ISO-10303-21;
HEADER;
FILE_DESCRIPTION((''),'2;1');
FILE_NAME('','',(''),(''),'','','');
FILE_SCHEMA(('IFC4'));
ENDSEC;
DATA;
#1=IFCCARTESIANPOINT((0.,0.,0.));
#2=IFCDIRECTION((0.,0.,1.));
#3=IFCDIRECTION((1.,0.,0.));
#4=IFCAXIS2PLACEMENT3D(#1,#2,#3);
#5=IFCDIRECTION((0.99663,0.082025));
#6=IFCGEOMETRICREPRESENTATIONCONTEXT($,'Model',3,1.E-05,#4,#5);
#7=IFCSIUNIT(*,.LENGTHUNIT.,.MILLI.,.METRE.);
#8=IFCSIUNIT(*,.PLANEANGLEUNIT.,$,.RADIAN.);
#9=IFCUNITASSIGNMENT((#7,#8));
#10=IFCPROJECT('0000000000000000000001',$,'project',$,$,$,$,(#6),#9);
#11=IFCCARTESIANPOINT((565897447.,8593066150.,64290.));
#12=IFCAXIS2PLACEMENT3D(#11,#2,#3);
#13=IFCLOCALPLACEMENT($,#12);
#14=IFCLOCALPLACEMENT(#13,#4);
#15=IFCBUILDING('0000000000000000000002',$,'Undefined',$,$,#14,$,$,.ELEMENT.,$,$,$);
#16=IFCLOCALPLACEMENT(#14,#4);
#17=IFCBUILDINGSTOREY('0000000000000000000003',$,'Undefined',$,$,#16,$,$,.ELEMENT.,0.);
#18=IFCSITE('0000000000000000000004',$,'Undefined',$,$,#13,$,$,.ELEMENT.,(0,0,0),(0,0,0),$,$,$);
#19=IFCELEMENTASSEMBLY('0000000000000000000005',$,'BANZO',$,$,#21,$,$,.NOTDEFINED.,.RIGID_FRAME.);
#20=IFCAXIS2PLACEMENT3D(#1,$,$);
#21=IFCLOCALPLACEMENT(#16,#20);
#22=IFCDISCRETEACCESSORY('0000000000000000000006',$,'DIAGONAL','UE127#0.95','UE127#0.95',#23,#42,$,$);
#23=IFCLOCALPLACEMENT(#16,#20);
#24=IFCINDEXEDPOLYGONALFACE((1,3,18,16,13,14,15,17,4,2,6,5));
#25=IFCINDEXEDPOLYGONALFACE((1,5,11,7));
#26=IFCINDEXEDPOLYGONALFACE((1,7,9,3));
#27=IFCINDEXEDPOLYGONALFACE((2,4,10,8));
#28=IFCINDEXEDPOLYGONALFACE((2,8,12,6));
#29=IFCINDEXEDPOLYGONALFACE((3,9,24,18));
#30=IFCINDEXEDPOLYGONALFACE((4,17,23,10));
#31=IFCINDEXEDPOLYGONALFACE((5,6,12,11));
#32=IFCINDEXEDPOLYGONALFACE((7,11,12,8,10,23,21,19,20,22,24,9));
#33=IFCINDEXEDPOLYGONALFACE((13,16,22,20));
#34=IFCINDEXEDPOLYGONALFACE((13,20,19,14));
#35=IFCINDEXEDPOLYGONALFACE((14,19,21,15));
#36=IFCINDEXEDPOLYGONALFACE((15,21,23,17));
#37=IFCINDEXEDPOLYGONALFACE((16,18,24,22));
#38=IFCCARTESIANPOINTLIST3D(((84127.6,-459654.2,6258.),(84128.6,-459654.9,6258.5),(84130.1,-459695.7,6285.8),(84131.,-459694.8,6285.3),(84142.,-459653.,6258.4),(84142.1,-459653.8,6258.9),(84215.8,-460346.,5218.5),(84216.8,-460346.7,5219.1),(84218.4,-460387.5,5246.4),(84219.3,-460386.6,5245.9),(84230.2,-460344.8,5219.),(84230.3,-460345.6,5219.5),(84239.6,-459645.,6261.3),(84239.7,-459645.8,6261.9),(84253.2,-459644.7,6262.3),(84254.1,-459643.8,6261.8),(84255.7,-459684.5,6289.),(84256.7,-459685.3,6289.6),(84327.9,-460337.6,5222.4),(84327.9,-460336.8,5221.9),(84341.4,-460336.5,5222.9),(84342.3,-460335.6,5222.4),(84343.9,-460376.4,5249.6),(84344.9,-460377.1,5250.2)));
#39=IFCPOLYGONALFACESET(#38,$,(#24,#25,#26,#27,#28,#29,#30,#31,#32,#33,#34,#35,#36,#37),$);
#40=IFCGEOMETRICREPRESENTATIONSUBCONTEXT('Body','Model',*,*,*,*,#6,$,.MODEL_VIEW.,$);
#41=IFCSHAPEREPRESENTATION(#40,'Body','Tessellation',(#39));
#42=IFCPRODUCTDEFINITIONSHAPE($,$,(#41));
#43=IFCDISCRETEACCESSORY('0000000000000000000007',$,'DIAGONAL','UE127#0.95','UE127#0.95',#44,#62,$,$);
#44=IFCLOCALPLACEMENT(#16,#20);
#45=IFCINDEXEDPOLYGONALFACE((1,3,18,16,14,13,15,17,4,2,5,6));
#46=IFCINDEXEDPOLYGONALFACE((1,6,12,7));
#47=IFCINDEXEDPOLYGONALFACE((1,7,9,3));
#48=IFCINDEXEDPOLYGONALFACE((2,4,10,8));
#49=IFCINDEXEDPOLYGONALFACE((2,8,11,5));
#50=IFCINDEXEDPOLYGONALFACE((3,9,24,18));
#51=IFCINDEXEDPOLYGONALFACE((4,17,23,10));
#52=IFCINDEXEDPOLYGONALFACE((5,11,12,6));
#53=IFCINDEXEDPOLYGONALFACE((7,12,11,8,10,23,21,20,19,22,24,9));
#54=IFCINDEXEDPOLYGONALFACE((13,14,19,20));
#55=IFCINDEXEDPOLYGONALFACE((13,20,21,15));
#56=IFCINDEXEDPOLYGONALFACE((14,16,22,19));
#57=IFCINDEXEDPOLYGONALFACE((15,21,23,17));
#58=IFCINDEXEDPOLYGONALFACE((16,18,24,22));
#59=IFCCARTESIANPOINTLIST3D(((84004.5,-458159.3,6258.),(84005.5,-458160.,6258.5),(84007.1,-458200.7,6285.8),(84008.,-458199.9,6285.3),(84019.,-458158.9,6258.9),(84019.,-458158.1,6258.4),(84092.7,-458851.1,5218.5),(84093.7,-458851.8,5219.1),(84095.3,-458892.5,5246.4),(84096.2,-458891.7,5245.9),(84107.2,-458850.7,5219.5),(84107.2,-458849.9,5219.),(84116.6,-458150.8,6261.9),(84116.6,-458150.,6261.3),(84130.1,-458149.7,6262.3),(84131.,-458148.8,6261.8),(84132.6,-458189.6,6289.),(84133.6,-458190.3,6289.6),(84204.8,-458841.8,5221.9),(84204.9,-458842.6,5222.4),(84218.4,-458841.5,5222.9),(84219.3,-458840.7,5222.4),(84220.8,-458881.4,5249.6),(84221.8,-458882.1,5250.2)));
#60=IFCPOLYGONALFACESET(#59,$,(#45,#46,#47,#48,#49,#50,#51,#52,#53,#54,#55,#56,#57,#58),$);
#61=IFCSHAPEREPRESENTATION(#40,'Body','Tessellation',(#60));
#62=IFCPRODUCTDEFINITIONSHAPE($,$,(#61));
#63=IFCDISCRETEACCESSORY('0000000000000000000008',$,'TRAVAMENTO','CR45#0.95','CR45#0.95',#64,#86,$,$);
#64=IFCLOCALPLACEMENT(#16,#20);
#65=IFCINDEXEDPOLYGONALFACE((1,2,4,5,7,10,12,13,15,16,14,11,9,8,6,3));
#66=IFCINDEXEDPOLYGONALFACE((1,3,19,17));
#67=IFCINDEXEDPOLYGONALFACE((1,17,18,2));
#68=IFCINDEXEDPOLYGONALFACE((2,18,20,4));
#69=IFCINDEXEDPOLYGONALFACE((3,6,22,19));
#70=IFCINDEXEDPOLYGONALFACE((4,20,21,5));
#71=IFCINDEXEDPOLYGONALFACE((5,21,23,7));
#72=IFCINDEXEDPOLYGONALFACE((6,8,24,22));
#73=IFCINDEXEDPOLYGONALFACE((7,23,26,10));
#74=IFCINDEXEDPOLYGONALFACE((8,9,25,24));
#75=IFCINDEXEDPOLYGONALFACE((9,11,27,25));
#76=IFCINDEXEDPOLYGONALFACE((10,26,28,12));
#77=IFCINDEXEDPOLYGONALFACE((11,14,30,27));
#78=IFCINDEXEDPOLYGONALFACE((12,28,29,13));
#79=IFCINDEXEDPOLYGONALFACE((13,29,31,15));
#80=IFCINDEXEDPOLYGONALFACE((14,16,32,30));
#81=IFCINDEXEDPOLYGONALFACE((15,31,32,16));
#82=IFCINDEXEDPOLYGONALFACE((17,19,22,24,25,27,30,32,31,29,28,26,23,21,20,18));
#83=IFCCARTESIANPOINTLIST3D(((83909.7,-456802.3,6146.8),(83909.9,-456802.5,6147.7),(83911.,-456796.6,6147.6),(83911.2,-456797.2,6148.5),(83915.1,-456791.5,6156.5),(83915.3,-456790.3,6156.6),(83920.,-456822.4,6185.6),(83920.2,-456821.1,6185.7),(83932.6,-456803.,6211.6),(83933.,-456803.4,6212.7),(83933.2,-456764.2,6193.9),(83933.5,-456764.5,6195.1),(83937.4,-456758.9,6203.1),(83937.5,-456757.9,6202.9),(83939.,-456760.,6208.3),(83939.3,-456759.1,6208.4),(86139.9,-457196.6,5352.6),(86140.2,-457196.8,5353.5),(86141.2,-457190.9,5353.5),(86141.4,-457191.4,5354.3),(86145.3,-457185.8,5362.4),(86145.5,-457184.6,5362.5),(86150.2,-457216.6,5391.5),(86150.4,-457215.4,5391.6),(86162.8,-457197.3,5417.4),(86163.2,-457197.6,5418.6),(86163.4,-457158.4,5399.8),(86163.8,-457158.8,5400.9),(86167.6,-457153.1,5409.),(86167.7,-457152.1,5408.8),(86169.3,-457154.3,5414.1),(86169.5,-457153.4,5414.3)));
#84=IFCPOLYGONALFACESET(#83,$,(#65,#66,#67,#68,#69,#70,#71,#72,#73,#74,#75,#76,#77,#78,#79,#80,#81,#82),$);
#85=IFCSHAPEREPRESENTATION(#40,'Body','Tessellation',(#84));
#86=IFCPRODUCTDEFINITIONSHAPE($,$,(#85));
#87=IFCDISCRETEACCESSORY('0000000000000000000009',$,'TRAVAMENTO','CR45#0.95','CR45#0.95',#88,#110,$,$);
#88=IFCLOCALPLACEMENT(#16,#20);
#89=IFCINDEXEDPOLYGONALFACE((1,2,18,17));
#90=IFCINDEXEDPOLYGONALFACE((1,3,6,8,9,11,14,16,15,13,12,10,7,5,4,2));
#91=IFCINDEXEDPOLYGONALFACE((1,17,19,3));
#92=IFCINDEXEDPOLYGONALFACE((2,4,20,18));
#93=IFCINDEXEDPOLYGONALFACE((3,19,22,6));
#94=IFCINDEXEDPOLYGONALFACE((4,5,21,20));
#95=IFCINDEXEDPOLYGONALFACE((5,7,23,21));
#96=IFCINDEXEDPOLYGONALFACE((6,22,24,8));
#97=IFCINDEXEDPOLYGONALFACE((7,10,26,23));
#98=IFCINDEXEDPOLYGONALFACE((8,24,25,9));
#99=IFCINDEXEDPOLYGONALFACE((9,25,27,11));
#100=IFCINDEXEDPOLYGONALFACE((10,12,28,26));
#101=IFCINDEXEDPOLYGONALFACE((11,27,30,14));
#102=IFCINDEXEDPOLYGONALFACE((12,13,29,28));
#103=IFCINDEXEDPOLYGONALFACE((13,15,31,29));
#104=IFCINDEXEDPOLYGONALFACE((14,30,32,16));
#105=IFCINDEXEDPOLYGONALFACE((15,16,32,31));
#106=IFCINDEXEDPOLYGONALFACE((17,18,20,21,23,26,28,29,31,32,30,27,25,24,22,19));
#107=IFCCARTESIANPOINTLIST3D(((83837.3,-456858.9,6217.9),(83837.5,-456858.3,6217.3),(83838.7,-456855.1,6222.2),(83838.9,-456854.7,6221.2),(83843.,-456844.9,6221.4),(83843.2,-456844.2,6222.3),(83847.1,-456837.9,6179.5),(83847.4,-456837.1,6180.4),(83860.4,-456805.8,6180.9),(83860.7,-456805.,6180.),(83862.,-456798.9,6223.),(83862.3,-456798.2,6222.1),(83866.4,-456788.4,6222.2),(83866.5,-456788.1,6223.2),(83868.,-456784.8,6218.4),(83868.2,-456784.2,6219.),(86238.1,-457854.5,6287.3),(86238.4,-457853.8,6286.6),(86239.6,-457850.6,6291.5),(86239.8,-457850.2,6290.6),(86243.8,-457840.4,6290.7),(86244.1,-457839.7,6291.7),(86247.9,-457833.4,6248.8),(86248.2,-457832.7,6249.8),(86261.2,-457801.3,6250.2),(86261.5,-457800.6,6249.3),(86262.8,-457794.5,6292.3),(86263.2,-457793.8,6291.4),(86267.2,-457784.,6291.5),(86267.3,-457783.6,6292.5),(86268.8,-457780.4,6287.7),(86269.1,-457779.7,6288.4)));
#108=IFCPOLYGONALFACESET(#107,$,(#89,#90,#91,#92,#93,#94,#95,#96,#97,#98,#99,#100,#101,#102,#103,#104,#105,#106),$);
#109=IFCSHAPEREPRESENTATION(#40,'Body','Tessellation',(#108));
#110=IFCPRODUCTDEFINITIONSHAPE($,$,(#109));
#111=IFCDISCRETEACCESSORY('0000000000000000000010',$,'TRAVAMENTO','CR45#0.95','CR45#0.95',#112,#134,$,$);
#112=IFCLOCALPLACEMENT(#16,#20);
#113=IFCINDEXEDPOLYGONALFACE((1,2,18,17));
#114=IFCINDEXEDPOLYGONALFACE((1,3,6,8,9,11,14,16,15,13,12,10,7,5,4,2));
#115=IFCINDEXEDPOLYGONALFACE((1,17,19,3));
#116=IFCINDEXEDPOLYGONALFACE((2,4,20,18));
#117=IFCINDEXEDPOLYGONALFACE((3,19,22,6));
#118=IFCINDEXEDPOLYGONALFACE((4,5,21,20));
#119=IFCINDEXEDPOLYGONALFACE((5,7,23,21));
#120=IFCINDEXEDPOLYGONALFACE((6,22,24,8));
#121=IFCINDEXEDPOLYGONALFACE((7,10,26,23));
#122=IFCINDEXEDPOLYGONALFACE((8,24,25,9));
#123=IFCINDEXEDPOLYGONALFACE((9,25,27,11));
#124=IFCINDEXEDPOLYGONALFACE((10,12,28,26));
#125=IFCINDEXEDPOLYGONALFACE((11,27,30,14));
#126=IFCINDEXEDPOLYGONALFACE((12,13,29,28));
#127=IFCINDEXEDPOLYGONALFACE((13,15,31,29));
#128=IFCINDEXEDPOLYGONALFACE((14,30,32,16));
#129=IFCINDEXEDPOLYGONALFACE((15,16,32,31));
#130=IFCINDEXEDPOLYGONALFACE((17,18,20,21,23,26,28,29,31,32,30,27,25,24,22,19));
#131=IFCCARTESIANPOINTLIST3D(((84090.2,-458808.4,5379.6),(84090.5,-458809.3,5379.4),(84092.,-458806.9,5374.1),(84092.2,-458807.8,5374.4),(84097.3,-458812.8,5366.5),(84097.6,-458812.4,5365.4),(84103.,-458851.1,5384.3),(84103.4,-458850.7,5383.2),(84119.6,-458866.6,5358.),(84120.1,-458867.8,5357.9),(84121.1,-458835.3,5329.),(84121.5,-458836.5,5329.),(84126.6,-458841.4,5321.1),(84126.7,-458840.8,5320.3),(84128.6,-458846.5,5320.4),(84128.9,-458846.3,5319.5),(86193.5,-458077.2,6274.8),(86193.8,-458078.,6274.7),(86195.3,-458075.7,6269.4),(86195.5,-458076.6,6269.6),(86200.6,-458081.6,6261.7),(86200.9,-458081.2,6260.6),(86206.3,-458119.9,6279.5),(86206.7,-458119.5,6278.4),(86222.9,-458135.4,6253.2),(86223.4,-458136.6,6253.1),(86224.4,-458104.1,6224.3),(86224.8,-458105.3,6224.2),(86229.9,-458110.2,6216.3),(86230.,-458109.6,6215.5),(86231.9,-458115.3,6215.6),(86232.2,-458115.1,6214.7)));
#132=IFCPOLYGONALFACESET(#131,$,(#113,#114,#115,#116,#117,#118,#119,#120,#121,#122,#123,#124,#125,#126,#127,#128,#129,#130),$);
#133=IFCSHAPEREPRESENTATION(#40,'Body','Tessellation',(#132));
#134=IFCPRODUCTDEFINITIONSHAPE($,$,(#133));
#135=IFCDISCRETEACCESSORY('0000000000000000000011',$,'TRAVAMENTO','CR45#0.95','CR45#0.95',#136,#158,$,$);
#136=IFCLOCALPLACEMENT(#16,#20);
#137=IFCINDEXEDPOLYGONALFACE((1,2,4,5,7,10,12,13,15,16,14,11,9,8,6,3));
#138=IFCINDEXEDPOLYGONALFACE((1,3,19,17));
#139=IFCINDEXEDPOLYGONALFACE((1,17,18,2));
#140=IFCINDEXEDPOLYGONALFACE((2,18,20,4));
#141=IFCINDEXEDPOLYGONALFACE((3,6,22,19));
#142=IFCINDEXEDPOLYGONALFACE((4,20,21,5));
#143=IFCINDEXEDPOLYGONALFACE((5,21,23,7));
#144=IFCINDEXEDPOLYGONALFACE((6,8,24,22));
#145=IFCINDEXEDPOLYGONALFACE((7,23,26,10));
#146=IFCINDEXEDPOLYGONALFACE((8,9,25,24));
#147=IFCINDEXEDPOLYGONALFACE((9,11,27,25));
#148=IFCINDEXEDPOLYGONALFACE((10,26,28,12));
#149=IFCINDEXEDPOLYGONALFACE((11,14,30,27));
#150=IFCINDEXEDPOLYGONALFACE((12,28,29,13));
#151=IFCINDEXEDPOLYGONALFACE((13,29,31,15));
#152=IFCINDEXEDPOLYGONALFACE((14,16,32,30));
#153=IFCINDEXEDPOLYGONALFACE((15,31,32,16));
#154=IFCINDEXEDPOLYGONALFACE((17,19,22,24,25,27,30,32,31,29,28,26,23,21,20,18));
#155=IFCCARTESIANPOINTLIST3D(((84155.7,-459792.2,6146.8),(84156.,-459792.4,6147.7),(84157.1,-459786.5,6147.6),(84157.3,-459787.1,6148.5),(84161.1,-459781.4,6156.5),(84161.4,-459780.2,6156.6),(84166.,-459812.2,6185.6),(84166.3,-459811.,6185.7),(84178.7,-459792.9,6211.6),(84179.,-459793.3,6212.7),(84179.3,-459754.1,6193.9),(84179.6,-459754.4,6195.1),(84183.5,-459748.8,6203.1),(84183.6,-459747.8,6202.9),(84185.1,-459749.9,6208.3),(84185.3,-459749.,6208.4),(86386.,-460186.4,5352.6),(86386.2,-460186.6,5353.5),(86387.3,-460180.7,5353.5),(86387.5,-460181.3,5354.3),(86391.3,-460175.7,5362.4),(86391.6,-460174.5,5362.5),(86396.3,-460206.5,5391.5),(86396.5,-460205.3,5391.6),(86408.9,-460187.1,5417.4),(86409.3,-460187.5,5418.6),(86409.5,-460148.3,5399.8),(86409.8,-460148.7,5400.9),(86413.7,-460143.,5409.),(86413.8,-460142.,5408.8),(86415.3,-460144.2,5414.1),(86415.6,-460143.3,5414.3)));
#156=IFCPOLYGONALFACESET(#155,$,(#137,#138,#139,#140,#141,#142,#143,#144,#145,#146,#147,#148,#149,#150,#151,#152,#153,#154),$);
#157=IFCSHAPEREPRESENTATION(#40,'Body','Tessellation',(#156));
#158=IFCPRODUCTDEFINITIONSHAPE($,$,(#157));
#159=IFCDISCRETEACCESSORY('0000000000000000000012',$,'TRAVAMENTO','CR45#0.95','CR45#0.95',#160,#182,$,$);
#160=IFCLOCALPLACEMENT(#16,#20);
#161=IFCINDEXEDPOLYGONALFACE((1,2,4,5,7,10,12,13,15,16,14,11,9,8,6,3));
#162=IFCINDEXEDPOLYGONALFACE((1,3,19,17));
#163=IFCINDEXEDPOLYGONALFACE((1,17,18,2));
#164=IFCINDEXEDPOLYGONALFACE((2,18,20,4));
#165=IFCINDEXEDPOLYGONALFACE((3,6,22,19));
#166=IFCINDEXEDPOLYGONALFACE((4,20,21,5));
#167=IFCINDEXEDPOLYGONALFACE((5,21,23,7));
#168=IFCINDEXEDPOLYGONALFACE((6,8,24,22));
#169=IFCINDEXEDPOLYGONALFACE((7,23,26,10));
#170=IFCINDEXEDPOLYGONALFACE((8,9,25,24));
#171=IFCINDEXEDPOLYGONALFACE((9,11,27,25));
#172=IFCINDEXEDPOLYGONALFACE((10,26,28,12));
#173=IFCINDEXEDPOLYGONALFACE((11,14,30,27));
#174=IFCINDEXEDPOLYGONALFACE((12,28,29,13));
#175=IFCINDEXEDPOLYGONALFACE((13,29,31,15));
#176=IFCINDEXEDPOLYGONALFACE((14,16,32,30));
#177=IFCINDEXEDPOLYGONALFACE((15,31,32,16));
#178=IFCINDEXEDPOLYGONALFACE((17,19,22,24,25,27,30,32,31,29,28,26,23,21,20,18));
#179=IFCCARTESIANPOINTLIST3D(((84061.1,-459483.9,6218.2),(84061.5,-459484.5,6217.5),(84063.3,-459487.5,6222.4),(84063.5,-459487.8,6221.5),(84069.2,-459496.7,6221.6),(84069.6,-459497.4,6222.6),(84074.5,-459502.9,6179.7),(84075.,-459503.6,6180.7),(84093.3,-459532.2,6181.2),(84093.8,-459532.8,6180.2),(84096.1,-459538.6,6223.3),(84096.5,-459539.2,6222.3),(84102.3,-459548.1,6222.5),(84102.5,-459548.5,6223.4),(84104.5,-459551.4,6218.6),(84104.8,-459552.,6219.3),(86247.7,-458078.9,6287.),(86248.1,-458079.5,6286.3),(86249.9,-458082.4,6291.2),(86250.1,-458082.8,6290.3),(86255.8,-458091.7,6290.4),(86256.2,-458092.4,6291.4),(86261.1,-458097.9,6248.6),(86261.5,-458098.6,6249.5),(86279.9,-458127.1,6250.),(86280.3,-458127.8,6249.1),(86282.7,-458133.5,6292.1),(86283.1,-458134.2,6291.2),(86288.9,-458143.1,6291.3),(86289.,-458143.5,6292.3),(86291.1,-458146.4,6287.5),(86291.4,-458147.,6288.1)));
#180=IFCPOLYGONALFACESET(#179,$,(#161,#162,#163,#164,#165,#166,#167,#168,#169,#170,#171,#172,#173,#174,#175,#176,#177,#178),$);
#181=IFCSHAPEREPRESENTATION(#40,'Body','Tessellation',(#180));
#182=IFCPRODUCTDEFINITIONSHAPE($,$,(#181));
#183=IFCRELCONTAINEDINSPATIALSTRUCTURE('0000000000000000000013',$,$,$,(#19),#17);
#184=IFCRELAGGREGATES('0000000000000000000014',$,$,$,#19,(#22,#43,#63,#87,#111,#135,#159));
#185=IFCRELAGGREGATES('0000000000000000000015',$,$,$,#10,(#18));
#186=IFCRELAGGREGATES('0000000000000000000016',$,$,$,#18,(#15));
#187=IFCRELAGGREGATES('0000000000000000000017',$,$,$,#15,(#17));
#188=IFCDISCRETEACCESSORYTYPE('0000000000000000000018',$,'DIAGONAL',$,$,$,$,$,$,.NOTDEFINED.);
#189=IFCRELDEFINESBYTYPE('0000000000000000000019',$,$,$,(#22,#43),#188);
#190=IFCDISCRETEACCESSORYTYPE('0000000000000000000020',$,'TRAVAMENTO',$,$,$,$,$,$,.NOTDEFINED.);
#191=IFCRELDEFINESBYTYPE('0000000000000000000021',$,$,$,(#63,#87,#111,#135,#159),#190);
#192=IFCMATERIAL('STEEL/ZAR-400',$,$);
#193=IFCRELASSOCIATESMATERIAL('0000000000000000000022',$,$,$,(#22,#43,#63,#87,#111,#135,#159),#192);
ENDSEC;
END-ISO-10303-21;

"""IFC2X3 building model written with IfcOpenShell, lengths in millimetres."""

from ifc_helpers import new_model, si_unit, direction, frame, frame_2d, origin_with_axes, place, context, subcontext, project, spatial, polyline, c_section, outline, extrude, material, type_object, element, aggregate, save


model = new_model("IFC2X3")

# Units and contexts
model_context = context("Model", 3, precision=1e-05, world=origin_with_axes(), true_north=direction((0.99663, 0.082025)))
body_context = subcontext(model_context, "Body", "Model", "MODEL_VIEW")
ifc_project = project(units=[si_unit("LENGTHUNIT", "METRE", prefix="MILLI"), si_unit("PLANEANGLEUNIT", "RADIAN")], contexts=[model_context])

# Site, building, storey
site_placement = place(None, frame((565897447.0, 8593066150.0, 64290.0), z_axis=(0.0, 0.0, 1.0), x_axis=(1.0, 0.0, 0.0)))
site = spatial("IfcSite", under=ifc_project, at=site_placement, Name="Undefined", CompositionType="ELEMENT", RefLatitude=(0, 0, 0), RefLongitude=(0, 0, 0))
building_placement = place(site_placement, origin_with_axes())
building = spatial("IfcBuilding", under=site, at=building_placement, Name="Undefined", CompositionType="ELEMENT")
storey_placement = place(building_placement, origin_with_axes())
storey = spatial("IfcBuildingStorey", under=building, at=storey_placement, Name="Undefined", CompositionType="ELEMENT", Elevation=0.0)

# Element assembly
assembly_1_placement = place(storey_placement, origin_with_axes())
assembly_1 = element("IfcElementAssembly", 1, at=assembly_1_placement, inside=storey, Name="BANZO", AssemblyPlace="NOTDEFINED", PredefinedType="RIGID_FRAME")

# Discrete accessories
ifc_material_1 = material(Name="STEEL/ZAR-400")
discrete_accessory_type_1 = type_object("IfcDiscreteAccessoryType", Name="DIAGONAL")
discrete_accessory_1_placement = place(assembly_1_placement, frame((84192.1, -459669.7, 6273.8), z_axis=(-0.996182, -0.081989, -0.029987), x_axis=(0.070485, -0.552697, -0.830396)))
discrete_accessory_1 = element("IfcDiscreteAccessory", 2, at=discrete_accessory_1_placement, type_object=discrete_accessory_type_1, material=ifc_material_1, Name="DIAGONAL", Description="UE127#0.95", ObjectType="UE127#0.95", context=body_context, shape_type="SweptSolid", body=[
    extrude(c_section(Depth=127.0, Width=50.0, WallThickness=0.9, Girth=14.5, at=frame_2d((0.0, 0.0), x_axis=(1.0, 0.0))), frame((1251.7, 0.0, 0.0), z_axis=(-1.0, 0.0, 0.0), x_axis=(0.0, -1.0, 0.0)), (0.0, 0.0, 1.0), 1251.7),
])
discrete_accessory_2_placement = place(assembly_1_placement, frame((84069.1, -458174.8, 6273.8), z_axis=(-0.996182, -0.081989, -0.029987), x_axis=(0.070485, -0.552697, -0.830396)))
discrete_accessory_2 = element("IfcDiscreteAccessory", 3, at=discrete_accessory_2_placement, type_object=discrete_accessory_type_1, material=ifc_material_1, Name="DIAGONAL", Description="UE127#0.95", ObjectType="UE127#0.95", context=body_context, shape_type="SweptSolid", body=[
    extrude(c_section(Depth=127.0, Width=50.0, WallThickness=0.9, Girth=14.5, at=frame_2d((0.0, 0.0), x_axis=(1.0, 0.0))), frame((1251.7, 0.0, 0.0), z_axis=(-1.0, 0.0, 0.0), x_axis=(0.0, -1.0, 0.0)), (0.0, 0.0, 1.0), 1251.7),
])
discrete_accessory_type_2 = type_object("IfcDiscreteAccessoryType", Name="TRAVAMENTO")
discrete_accessory_3_placement = place(assembly_1_placement, frame((86155.5, -457189.5, 5392.8), z_axis=(0.05151, -0.82934, 0.556366), x_axis=(-0.929259, 0.164269, 0.330898)))
discrete_accessory_3 = element("IfcDiscreteAccessory", 4, at=discrete_accessory_3_placement, type_object=discrete_accessory_type_2, material=ifc_material_1, Name="TRAVAMENTO", Description="CR45#0.95", ObjectType="CR45#0.95", context=body_context, shape_type="SweptSolid", body=[
    extrude(outline(polyline([(-35.5, -20.5), (-24.9, -20.5), (-17.4, 21.5), (18.1, 21.5), (25.6, -20.5), (36.2, -20.5), (40.1, -16.6), (40.8, -17.3), (36.6, -21.5), (24.8, -21.5), (17.3, 20.5), (-16.6, 20.5), (-24.1, -21.5), (-35.9, -21.5), (-40.1, -17.3), (-39.4, -16.6), (-35.5, -20.5)])), frame((2400.0, 0.0, 0.0), z_axis=(-1.0, 0.0, 0.0), x_axis=(0.0, -1.0, 0.0)), (0.0, 0.0, 1.0), 2400.0),
])
discrete_accessory_4_placement = place(assembly_1_placement, frame((86254.2, -457816.7, 6270.5), z_axis=(0.029887, 0.002459, -0.99955), x_axis=(-0.923403, 0.382903, -0.026668)))
discrete_accessory_4 = element("IfcDiscreteAccessory", 5, at=discrete_accessory_4_placement, type_object=discrete_accessory_type_2, material=ifc_material_1, Name="TRAVAMENTO", Description="CR45#0.95", ObjectType="CR45#0.95", context=body_context, shape_type="SweptSolid", body=[
    extrude(outline(polyline([(-35.5, -20.5), (-24.9, -20.5), (-17.4, 21.5), (18.1, 21.5), (25.6, -20.5), (36.2, -20.5), (40.1, -16.6), (40.8, -17.3), (36.6, -21.5), (24.8, -21.5), (17.3, 20.5), (-16.6, 20.5), (-24.1, -21.5), (-35.9, -21.5), (-40.1, -17.3), (-39.4, -16.6), (-35.5, -20.5)])), frame((2600.0, 0.0, 0.0), z_axis=(-1.0, 0.0, 0.0), x_axis=(0.0, -1.0, 0.0)), (0.0, 0.0, 1.0), 2600.0),
])
discrete_accessory_5_placement = place(assembly_1_placement, frame((84110.3, -458841.5, 5359.4), z_axis=(0.05151, -0.82934, 0.556366), x_axis=(0.876377, 0.30467, 0.373015)))
discrete_accessory_5 = element("IfcDiscreteAccessory", 6, at=discrete_accessory_5_placement, type_object=discrete_accessory_type_2, material=ifc_material_1, Name="TRAVAMENTO", Description="CR45#0.95", ObjectType="CR45#0.95", context=body_context, shape_type="SweptSolid", body=[
    extrude(outline(polyline([(-35.5, -20.5), (-24.9, -20.5), (-17.4, 21.5), (18.1, 21.5), (25.6, -20.5), (36.2, -20.5), (40.1, -16.6), (40.8, -17.3), (36.6, -21.5), (24.8, -21.5), (17.3, 20.5), (-16.6, 20.5), (-24.1, -21.5), (-35.9, -21.5), (-40.1, -17.3), (-39.4, -16.6), (-35.5, -20.5)])), frame((2400.0, 0.0, 0.0), z_axis=(-1.0, 0.0, 0.0), x_axis=(0.0, -1.0, 0.0)), (0.0, 0.0, 1.0), 2400.0),
])
discrete_accessory_6_placement = place(assembly_1_placement, frame((86401.5, -460179.4, 5392.8), z_axis=(0.05151, -0.82934, 0.556366), x_axis=(-0.929259, 0.164269, 0.330898)))
discrete_accessory_6 = element("IfcDiscreteAccessory", 7, at=discrete_accessory_6_placement, type_object=discrete_accessory_type_2, material=ifc_material_1, Name="TRAVAMENTO", Description="CR45#0.95", ObjectType="CR45#0.95", context=body_context, shape_type="SweptSolid", body=[
    extrude(outline(polyline([(-35.5, -20.5), (-24.9, -20.5), (-17.4, 21.5), (18.1, 21.5), (25.6, -20.5), (36.2, -20.5), (40.1, -16.6), (40.8, -17.3), (36.6, -21.5), (24.8, -21.5), (17.3, 20.5), (-16.6, 20.5), (-24.1, -21.5), (-35.9, -21.5), (-40.1, -17.3), (-39.4, -16.6), (-35.5, -20.5)])), frame((2400.0, 0.0, 0.0), z_axis=(-1.0, 0.0, 0.0), x_axis=(0.0, -1.0, 0.0)), (0.0, 0.0, 1.0), 2400.0),
])
discrete_accessory_7_placement = place(assembly_1_placement, frame((84083.7, -459518.2, 6201.4), z_axis=(0.029886, 0.00246, -0.99955), x_axis=(0.840995, 0.540395, 0.026476)))
discrete_accessory_7 = element("IfcDiscreteAccessory", 8, at=discrete_accessory_7_placement, type_object=discrete_accessory_type_2, material=ifc_material_1, Name="TRAVAMENTO", Description="CR45#0.95", ObjectType="CR45#0.95", context=body_context, shape_type="SweptSolid", body=[
    extrude(outline(polyline([(-35.5, -20.5), (-24.9, -20.5), (-17.4, 21.5), (18.1, 21.5), (25.6, -20.5), (36.2, -20.5), (40.1, -16.6), (40.8, -17.3), (36.6, -21.5), (24.8, -21.5), (17.3, 20.5), (-16.6, 20.5), (-24.1, -21.5), (-35.9, -21.5), (-40.1, -17.3), (-39.4, -16.6), (-35.5, -20.5)])), frame((2600.0, 0.0, 0.0), z_axis=(-1.0, 0.0, 0.0), x_axis=(0.0, -1.0, 0.0)), (0.0, 0.0, 1.0), 2600.0),
])
aggregate(assembly_1, [discrete_accessory_1, discrete_accessory_2, discrete_accessory_3, discrete_accessory_4, discrete_accessory_5, discrete_accessory_6, discrete_accessory_7])

save(model, "model.ifc")
